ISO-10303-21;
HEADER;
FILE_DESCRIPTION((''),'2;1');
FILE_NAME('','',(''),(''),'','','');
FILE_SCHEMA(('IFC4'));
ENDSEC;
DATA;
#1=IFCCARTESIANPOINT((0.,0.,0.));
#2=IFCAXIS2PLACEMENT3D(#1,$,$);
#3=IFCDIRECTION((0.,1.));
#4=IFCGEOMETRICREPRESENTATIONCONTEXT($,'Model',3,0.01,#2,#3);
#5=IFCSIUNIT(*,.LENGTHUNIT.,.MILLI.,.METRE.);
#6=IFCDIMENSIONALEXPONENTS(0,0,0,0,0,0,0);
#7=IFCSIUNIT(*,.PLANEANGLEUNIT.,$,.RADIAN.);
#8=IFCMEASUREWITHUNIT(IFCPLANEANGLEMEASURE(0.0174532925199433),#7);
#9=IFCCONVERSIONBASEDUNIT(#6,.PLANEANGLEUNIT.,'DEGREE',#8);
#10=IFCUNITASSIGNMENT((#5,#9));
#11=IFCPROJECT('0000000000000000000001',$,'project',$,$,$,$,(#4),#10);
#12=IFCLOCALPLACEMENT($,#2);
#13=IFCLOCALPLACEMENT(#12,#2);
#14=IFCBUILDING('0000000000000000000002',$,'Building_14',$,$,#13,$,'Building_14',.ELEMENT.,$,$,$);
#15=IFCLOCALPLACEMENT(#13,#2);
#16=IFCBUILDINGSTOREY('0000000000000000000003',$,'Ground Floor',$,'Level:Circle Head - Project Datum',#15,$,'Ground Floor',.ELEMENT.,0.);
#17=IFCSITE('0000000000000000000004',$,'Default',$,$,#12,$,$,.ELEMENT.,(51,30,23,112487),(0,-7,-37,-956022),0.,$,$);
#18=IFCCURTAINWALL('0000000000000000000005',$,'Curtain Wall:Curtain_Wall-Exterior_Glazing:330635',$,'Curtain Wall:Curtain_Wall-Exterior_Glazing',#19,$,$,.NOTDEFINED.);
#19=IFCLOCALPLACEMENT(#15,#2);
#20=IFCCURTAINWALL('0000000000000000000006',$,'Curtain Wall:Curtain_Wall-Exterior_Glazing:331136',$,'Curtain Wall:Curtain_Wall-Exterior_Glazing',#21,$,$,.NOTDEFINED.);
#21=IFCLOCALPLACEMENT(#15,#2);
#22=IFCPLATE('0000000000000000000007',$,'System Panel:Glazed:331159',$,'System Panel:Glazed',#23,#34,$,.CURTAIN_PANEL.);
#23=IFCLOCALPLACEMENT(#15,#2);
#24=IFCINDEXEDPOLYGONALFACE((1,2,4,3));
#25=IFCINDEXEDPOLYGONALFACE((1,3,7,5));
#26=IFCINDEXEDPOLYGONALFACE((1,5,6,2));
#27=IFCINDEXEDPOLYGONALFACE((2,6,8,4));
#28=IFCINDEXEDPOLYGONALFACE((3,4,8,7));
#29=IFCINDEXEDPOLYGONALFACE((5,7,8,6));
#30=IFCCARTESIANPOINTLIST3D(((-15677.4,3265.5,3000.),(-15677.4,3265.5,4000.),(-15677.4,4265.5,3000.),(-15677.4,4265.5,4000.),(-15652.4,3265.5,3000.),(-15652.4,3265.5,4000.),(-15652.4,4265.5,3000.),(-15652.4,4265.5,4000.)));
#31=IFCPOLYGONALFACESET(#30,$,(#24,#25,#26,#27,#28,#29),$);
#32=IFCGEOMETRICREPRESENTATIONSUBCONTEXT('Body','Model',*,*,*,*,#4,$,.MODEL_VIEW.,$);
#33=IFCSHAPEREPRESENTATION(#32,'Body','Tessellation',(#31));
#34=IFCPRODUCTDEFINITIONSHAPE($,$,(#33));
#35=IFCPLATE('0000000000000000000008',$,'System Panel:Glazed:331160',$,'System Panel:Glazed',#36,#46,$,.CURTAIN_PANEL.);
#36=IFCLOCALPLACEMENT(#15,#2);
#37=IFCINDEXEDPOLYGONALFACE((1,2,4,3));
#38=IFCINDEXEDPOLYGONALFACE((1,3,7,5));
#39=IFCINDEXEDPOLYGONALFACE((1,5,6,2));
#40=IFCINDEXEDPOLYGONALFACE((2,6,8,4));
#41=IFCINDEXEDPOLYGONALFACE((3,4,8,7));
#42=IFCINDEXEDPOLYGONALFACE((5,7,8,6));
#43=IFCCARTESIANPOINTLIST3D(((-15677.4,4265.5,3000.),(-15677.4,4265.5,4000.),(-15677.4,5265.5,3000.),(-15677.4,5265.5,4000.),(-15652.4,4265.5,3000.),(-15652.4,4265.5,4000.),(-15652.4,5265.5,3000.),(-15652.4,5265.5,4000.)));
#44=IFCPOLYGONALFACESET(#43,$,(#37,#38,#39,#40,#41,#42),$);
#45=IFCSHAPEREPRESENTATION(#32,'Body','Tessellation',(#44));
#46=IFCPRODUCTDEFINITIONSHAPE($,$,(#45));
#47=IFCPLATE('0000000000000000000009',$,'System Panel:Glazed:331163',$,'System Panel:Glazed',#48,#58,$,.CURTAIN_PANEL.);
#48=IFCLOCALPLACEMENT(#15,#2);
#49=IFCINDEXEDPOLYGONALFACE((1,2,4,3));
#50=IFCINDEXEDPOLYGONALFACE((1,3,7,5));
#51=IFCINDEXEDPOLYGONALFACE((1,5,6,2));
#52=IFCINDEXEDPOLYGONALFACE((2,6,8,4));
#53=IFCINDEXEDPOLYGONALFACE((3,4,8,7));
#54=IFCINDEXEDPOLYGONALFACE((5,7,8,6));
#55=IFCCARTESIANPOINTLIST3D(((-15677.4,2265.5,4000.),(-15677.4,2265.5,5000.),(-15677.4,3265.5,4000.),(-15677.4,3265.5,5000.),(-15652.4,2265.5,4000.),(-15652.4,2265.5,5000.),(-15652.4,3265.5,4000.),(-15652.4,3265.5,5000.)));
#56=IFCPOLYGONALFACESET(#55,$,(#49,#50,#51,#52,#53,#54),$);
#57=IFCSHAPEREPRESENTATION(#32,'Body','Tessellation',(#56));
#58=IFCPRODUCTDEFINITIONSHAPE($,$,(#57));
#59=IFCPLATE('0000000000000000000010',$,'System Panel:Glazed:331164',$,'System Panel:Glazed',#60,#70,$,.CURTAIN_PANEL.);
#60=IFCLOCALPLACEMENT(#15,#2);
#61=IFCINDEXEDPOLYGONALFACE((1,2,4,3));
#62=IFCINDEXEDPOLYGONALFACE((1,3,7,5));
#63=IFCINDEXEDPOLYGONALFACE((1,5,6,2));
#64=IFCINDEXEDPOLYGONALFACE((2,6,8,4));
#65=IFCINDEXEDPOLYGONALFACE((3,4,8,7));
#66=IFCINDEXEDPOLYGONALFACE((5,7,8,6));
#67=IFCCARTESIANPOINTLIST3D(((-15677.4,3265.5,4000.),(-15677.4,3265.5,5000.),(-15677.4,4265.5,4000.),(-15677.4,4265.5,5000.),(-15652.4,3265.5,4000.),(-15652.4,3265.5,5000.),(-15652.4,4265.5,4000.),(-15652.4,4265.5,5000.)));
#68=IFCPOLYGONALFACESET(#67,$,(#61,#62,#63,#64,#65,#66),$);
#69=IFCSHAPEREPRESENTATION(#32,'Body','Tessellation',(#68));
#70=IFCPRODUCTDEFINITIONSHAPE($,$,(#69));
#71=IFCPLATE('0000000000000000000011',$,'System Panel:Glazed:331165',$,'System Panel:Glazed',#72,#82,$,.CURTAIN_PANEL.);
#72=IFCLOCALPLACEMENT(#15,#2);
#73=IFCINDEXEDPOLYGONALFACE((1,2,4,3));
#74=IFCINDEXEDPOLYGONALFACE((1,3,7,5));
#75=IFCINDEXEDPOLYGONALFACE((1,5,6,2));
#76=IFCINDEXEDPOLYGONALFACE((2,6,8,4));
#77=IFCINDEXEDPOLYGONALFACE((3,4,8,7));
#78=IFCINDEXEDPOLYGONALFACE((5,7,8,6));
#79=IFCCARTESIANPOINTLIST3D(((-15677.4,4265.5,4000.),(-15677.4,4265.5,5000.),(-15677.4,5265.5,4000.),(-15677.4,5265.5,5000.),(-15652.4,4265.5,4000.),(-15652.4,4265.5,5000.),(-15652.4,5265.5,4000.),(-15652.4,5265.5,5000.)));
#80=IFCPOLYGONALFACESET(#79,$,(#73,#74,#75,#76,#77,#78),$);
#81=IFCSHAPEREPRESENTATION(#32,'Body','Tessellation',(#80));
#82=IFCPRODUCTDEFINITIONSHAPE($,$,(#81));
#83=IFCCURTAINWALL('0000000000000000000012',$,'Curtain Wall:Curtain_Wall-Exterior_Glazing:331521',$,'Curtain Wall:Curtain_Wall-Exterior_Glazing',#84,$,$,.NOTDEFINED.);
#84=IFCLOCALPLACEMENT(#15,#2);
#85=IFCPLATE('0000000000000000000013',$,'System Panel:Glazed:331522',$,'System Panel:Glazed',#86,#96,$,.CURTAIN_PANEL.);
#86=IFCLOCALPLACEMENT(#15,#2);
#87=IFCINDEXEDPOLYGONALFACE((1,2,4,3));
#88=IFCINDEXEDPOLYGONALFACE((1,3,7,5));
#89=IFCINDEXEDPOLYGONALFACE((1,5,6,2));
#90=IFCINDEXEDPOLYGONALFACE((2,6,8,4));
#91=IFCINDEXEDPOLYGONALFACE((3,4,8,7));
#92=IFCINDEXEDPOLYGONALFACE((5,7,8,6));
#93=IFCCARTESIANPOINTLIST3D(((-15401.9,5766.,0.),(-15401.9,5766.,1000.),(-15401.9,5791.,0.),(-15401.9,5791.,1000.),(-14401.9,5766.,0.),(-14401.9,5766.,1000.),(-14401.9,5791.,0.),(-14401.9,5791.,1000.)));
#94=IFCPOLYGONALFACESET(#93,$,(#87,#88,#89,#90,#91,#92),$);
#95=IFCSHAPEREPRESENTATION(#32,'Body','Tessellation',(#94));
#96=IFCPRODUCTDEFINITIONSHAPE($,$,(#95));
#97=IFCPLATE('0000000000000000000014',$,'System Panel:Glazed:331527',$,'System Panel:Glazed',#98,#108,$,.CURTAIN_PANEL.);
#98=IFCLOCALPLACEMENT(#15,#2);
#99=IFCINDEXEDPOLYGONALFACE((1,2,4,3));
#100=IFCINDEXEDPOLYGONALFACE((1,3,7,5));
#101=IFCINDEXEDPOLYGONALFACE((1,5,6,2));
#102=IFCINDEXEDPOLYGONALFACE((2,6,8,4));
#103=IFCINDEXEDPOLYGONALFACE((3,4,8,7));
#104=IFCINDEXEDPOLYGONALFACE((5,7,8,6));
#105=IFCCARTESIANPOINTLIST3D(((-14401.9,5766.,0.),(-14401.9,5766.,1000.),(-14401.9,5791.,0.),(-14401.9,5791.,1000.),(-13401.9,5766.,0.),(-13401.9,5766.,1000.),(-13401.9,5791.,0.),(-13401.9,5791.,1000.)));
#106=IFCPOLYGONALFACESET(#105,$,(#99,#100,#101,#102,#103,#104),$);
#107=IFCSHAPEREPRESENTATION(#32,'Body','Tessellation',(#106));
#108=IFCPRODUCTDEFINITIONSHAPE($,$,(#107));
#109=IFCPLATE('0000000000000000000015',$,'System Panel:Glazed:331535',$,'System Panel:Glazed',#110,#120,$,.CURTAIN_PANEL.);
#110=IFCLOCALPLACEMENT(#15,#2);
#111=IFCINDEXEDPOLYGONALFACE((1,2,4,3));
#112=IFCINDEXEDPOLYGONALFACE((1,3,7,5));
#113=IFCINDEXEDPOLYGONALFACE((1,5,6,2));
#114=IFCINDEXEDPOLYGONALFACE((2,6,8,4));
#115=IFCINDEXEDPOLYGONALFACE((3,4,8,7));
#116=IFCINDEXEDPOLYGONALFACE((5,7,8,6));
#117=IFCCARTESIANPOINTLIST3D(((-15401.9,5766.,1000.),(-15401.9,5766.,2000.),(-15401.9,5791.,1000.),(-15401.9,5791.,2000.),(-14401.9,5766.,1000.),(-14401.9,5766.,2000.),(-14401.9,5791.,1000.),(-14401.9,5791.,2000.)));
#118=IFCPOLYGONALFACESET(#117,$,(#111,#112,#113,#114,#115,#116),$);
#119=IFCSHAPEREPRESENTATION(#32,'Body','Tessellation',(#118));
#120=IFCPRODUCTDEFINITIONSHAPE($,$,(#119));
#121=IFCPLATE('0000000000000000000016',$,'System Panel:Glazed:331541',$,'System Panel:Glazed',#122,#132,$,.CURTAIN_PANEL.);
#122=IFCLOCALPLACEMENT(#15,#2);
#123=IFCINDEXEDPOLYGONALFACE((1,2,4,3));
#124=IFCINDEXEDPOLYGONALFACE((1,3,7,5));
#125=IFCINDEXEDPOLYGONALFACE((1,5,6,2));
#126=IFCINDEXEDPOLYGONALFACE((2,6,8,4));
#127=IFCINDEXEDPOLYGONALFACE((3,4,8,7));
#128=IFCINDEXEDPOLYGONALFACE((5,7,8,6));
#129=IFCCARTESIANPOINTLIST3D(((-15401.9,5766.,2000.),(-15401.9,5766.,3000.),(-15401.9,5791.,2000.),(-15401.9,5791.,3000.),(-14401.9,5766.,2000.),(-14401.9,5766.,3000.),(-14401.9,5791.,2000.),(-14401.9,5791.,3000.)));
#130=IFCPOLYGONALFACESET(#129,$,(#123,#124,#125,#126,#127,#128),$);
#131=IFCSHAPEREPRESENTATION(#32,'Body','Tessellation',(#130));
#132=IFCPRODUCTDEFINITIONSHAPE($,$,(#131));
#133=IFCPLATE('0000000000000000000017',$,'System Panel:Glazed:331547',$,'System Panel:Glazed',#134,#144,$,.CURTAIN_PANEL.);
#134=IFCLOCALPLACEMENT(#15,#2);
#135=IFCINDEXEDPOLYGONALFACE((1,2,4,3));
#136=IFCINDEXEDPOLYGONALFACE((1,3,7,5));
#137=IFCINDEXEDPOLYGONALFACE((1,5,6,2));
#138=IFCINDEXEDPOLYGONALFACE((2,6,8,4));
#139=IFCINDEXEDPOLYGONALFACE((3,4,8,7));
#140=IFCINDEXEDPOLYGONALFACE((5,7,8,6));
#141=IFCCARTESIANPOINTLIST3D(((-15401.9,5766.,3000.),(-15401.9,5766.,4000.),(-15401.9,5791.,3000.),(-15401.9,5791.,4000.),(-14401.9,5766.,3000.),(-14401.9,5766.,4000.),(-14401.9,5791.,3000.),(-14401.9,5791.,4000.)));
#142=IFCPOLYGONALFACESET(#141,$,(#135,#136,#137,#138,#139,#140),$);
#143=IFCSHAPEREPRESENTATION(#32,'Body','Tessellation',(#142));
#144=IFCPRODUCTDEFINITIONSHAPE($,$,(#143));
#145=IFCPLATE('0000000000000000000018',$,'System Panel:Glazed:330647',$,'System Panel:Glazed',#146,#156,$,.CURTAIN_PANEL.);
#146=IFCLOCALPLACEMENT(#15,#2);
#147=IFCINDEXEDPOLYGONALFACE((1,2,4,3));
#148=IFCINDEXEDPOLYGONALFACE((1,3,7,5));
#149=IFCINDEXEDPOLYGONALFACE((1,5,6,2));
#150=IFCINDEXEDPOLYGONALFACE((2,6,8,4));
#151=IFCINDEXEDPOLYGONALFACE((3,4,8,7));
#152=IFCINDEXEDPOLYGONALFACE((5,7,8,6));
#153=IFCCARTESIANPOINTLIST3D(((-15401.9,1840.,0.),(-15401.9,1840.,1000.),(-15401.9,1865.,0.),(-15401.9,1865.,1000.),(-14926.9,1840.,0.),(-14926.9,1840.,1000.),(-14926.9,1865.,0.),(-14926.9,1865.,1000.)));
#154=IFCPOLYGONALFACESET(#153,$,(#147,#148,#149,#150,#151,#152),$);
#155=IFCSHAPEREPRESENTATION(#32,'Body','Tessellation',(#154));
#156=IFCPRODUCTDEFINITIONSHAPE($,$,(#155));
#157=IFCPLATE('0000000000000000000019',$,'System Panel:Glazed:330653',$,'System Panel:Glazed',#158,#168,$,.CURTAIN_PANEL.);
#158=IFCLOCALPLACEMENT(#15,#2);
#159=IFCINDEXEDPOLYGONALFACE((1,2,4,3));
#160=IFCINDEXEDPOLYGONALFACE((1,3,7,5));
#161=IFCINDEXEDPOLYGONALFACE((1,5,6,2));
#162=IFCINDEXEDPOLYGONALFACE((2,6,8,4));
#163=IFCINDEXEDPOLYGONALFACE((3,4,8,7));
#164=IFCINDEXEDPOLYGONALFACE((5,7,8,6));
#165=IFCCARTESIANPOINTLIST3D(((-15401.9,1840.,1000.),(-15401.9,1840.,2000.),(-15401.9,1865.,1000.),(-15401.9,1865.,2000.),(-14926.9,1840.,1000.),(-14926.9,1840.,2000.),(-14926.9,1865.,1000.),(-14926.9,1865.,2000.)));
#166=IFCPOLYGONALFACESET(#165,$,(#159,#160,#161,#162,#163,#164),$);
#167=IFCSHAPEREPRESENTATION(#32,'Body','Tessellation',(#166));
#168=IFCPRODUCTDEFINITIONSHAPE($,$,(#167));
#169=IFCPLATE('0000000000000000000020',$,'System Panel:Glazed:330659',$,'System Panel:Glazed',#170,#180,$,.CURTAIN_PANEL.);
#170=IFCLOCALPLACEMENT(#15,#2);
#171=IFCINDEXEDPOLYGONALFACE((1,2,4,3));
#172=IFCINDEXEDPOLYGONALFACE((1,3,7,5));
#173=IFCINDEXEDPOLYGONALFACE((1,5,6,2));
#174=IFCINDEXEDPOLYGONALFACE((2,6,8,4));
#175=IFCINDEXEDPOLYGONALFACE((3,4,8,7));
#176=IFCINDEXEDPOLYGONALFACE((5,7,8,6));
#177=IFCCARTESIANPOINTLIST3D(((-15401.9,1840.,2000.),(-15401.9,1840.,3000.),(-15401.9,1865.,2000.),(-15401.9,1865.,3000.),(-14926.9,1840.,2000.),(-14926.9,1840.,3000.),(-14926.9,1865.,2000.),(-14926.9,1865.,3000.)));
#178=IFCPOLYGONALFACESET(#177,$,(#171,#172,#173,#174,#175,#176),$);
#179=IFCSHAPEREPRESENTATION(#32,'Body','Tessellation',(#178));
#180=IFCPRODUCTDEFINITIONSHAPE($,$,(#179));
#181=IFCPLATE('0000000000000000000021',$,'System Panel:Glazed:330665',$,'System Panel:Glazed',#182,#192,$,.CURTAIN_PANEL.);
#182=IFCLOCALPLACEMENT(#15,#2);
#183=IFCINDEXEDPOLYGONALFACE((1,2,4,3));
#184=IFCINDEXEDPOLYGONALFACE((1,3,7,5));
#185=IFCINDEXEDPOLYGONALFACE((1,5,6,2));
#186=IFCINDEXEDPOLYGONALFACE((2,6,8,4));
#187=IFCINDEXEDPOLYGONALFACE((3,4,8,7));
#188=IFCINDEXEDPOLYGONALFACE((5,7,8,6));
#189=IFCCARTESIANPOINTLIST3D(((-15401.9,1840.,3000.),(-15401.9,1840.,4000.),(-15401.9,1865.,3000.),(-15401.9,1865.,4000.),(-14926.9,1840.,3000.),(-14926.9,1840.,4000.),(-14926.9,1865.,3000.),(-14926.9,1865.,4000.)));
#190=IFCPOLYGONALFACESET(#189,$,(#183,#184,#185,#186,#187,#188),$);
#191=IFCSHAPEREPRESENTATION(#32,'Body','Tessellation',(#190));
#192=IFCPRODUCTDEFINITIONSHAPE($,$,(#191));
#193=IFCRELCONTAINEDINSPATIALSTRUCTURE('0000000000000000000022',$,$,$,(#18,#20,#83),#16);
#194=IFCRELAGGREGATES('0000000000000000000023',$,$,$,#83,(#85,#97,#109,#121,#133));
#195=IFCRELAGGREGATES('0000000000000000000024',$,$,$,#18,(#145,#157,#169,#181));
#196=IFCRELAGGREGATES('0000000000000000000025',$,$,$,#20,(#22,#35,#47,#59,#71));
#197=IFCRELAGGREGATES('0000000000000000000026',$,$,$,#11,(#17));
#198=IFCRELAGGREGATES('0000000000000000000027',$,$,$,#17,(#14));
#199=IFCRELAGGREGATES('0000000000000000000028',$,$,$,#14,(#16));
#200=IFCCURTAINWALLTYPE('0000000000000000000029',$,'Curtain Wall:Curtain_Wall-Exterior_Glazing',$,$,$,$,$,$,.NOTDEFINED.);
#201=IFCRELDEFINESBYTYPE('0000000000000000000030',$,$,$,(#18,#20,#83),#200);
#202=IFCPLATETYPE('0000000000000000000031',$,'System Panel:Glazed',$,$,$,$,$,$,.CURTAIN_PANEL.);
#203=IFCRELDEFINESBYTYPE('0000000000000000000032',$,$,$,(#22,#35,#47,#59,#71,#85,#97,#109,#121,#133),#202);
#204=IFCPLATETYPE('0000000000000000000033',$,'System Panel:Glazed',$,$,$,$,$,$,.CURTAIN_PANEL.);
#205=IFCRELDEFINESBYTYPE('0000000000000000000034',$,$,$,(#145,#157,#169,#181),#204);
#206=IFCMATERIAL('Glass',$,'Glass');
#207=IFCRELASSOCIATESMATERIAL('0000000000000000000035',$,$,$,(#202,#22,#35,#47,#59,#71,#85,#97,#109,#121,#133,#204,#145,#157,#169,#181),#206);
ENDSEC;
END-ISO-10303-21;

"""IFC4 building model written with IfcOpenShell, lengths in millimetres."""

from ifc_helpers import new_model, entity, si_unit, converted_unit, direction, frame, origin, place, context, subcontext, project, spatial, indexed_curve, outline, extrude, source, transform, mapped, material, type_object, type_shapes, element, aggregate, save


model = new_model("IFC4")

# Units and contexts
model_context = context("Model", 3, precision=0.01, world=origin(), true_north=direction((0.0, 1.0)))
body_context = subcontext(model_context, "Body", "Model", "MODEL_VIEW")
ifc_project = project(units=[si_unit("LENGTHUNIT", "METRE", prefix="MILLI"), converted_unit("PLANEANGLEUNIT", "DEGREE", entity("IfcPlaneAngleMeasure", 0.0174532925199433), si_unit("PLANEANGLEUNIT", "RADIAN"), dimensions=[0, 0, 0, 0, 0, 0, 0])], contexts=[model_context])

# Site, building, storey
site_placement = place(None, origin())
site = spatial("IfcSite", under=ifc_project, at=site_placement, Name="Default", CompositionType="ELEMENT", RefLatitude=(51, 30, 23, 112487), RefLongitude=(0, -7, -37, -956022), RefElevation=0.0)
building_placement = place(site_placement, origin())
building = spatial("IfcBuilding", under=site, at=building_placement, Name="Building_14", LongName="Building_14", CompositionType="ELEMENT")
storey_placement = place(building_placement, origin())
storey = spatial("IfcBuildingStorey", under=building, at=storey_placement, Name="Ground Floor", ObjectType="Level:Circle Head - Project Datum", LongName="Ground Floor", CompositionType="ELEMENT", Elevation=0.0)

# Curtain walls, plates
curtain_wall_type = type_object("IfcCurtainWallType", Name="Curtain Wall:Curtain_Wall-Exterior_Glazing", PredefinedType="NOTDEFINED")
curtain_wall_1_placement = place(storey_placement, origin())
curtain_wall_1 = element("IfcCurtainWall", 1, at=curtain_wall_1_placement, inside=storey, type_object=curtain_wall_type, Name="Curtain Wall:Curtain_Wall-Exterior_Glazing:330635", ObjectType="Curtain Wall:Curtain_Wall-Exterior_Glazing", PredefinedType="NOTDEFINED")
ifc_material = material(Name="Glass", Category="Glass")
plate_type_1 = type_object("IfcPlateType", Name="System Panel:Glazed", PredefinedType="CURTAIN_PANEL", material=ifc_material)
shared_shape_1 = source(origin(), body_context, "Body", "SweptSolid", [
    extrude(outline(indexed_curve([(-12.5, -500.0), (12.5, -500.0), (12.5, 500.0), (-12.5, 500.0), (-12.5, -500.0)], self_intersect=False)), frame((0.0, -37.0, 0.0), z_axis=(0.0, 0.0, 1.0), x_axis=(0.0, 1.0, 0.0)), (0.0, 0.0, 1.0), 1000.0),
])
type_shapes(plate_type_1, [shared_shape_1])
curtain_wall_2_placement = place(storey_placement, origin())
curtain_wall_2 = element("IfcCurtainWall", 2, at=curtain_wall_2_placement, inside=storey, type_object=curtain_wall_type, Name="Curtain Wall:Curtain_Wall-Exterior_Glazing:331136", ObjectType="Curtain Wall:Curtain_Wall-Exterior_Glazing", PredefinedType="NOTDEFINED")
plate_1_placement = place(curtain_wall_2_placement, frame((-15701.9, 3765.5, 3000.0), z_axis=(0.0, 0.0, 1.0), x_axis=(0.0, 1.0, 0.0)))
plate_1 = element("IfcPlate", 3, at=plate_1_placement, type_object=plate_type_1, material=ifc_material, Name="System Panel:Glazed:331159", ObjectType="System Panel:Glazed", PredefinedType="CURTAIN_PANEL", context=body_context, shape_type="MappedRepresentation", body=[
    mapped(shared_shape_1, transform((0.0, 0.0, 0.0), scale=1.0)),
])
plate_2_placement = place(curtain_wall_2_placement, frame((-15701.9, 4765.5, 3000.0), z_axis=(0.0, 0.0, 1.0), x_axis=(0.0, 1.0, 0.0)))
plate_2 = element("IfcPlate", 4, at=plate_2_placement, type_object=plate_type_1, material=ifc_material, Name="System Panel:Glazed:331160", ObjectType="System Panel:Glazed", PredefinedType="CURTAIN_PANEL", context=body_context, shape_type="MappedRepresentation", body=[
    mapped(shared_shape_1, transform((0.0, 0.0, 0.0), scale=1.0)),
])
plate_3_placement = place(curtain_wall_2_placement, frame((-15701.9, 2765.5, 4000.0), z_axis=(0.0, 0.0, 1.0), x_axis=(0.0, 1.0, 0.0)))
plate_3 = element("IfcPlate", 5, at=plate_3_placement, type_object=plate_type_1, material=ifc_material, Name="System Panel:Glazed:331163", ObjectType="System Panel:Glazed", PredefinedType="CURTAIN_PANEL", context=body_context, shape_type="MappedRepresentation", body=[
    mapped(shared_shape_1, transform((0.0, 0.0, 0.0), scale=1.0)),
])
plate_4_placement = place(curtain_wall_2_placement, frame((-15701.9, 3765.5, 4000.0), z_axis=(0.0, 0.0, 1.0), x_axis=(0.0, 1.0, 0.0)))
plate_4 = element("IfcPlate", 6, at=plate_4_placement, type_object=plate_type_1, material=ifc_material, Name="System Panel:Glazed:331164", ObjectType="System Panel:Glazed", PredefinedType="CURTAIN_PANEL", context=body_context, shape_type="MappedRepresentation", body=[
    mapped(shared_shape_1, transform((0.0, 0.0, 0.0), scale=1.0)),
])
plate_5_placement = place(curtain_wall_2_placement, frame((-15701.9, 4765.5, 4000.0), z_axis=(0.0, 0.0, 1.0), x_axis=(0.0, 1.0, 0.0)))
plate_5 = element("IfcPlate", 7, at=plate_5_placement, type_object=plate_type_1, material=ifc_material, Name="System Panel:Glazed:331165", ObjectType="System Panel:Glazed", PredefinedType="CURTAIN_PANEL", context=body_context, shape_type="MappedRepresentation", body=[
    mapped(shared_shape_1, transform((0.0, 0.0, 0.0), scale=1.0)),
])
curtain_wall_3_placement = place(storey_placement, origin())
curtain_wall_3 = element("IfcCurtainWall", 8, at=curtain_wall_3_placement, inside=storey, type_object=curtain_wall_type, Name="Curtain Wall:Curtain_Wall-Exterior_Glazing:331521", ObjectType="Curtain Wall:Curtain_Wall-Exterior_Glazing", PredefinedType="NOTDEFINED")
plate_6_placement = place(curtain_wall_3_placement, frame((-14901.9, 5815.5, 0.0)))
plate_6 = element("IfcPlate", 9, at=plate_6_placement, type_object=plate_type_1, material=ifc_material, Name="System Panel:Glazed:331522", ObjectType="System Panel:Glazed", PredefinedType="CURTAIN_PANEL", context=body_context, shape_type="MappedRepresentation", body=[
    mapped(shared_shape_1, transform((0.0, 0.0, 0.0), scale=1.0)),
])
plate_7_placement = place(curtain_wall_3_placement, frame((-13901.9, 5815.5, 0.0)))
plate_7 = element("IfcPlate", 10, at=plate_7_placement, type_object=plate_type_1, material=ifc_material, Name="System Panel:Glazed:331527", ObjectType="System Panel:Glazed", PredefinedType="CURTAIN_PANEL", context=body_context, shape_type="MappedRepresentation", body=[
    mapped(shared_shape_1, transform((0.0, 0.0, 0.0), scale=1.0)),
])
plate_8_placement = place(curtain_wall_3_placement, frame((-14901.9, 5815.5, 1000.0)))
plate_8 = element("IfcPlate", 11, at=plate_8_placement, type_object=plate_type_1, material=ifc_material, Name="System Panel:Glazed:331535", ObjectType="System Panel:Glazed", PredefinedType="CURTAIN_PANEL", context=body_context, shape_type="MappedRepresentation", body=[
    mapped(shared_shape_1, transform((0.0, 0.0, 0.0), scale=1.0)),
])
plate_9_placement = place(curtain_wall_3_placement, frame((-14901.9, 5815.5, 2000.0)))
plate_9 = element("IfcPlate", 12, at=plate_9_placement, type_object=plate_type_1, material=ifc_material, Name="System Panel:Glazed:331541", ObjectType="System Panel:Glazed", PredefinedType="CURTAIN_PANEL", context=body_context, shape_type="MappedRepresentation", body=[
    mapped(shared_shape_1, transform((0.0, 0.0, 0.0), scale=1.0)),
])
plate_10_placement = place(curtain_wall_3_placement, frame((-14901.9, 5815.5, 3000.0)))
plate_10 = element("IfcPlate", 13, at=plate_10_placement, type_object=plate_type_1, material=ifc_material, Name="System Panel:Glazed:331547", ObjectType="System Panel:Glazed", PredefinedType="CURTAIN_PANEL", context=body_context, shape_type="MappedRepresentation", body=[
    mapped(shared_shape_1, transform((0.0, 0.0, 0.0), scale=1.0)),
])
aggregate(curtain_wall_3, [plate_6, plate_7, plate_8, plate_9, plate_10])

# Plates
plate_type_2 = type_object("IfcPlateType", Name="System Panel:Glazed", PredefinedType="CURTAIN_PANEL", material=ifc_material)
shared_shape_2 = source(origin(), body_context, "Body", "SweptSolid", [
    extrude(outline(indexed_curve([(-12.5, -237.5), (12.5, -237.5), (12.5, 237.5), (-12.5, 237.5), (-12.5, -237.5)], self_intersect=False)), frame((0.0, -37.0, 0.0), z_axis=(0.0, 0.0, 1.0), x_axis=(0.0, 1.0, 0.0)), (0.0, 0.0, 1.0), 1000.0),
])
type_shapes(plate_type_2, [shared_shape_2])
plate_11_placement = place(curtain_wall_1_placement, frame((-15164.4, 1815.5, 0.0), z_axis=(0.0, 0.0, 1.0), x_axis=(-1.0, 0.0, 0.0)))
plate_11 = element("IfcPlate", 14, at=plate_11_placement, type_object=plate_type_2, material=ifc_material, Name="System Panel:Glazed:330647", ObjectType="System Panel:Glazed", PredefinedType="CURTAIN_PANEL", context=body_context, shape_type="MappedRepresentation", body=[
    mapped(shared_shape_2, transform((0.0, 0.0, 0.0), scale=1.0)),
])
plate_12_placement = place(curtain_wall_1_placement, frame((-15164.4, 1815.5, 1000.0), z_axis=(0.0, 0.0, 1.0), x_axis=(-1.0, 0.0, 0.0)))
plate_12 = element("IfcPlate", 15, at=plate_12_placement, type_object=plate_type_2, material=ifc_material, Name="System Panel:Glazed:330653", ObjectType="System Panel:Glazed", PredefinedType="CURTAIN_PANEL", context=body_context, shape_type="MappedRepresentation", body=[
    mapped(shared_shape_2, transform((0.0, 0.0, 0.0), scale=1.0)),
])
plate_13_placement = place(curtain_wall_1_placement, frame((-15164.4, 1815.5, 2000.0), z_axis=(0.0, 0.0, 1.0), x_axis=(-1.0, 0.0, 0.0)))
plate_13 = element("IfcPlate", 16, at=plate_13_placement, type_object=plate_type_2, material=ifc_material, Name="System Panel:Glazed:330659", ObjectType="System Panel:Glazed", PredefinedType="CURTAIN_PANEL", context=body_context, shape_type="MappedRepresentation", body=[
    mapped(shared_shape_2, transform((0.0, 0.0, 0.0), scale=1.0)),
])
plate_14_placement = place(curtain_wall_1_placement, frame((-15164.4, 1815.5, 3000.0), z_axis=(0.0, 0.0, 1.0), x_axis=(-1.0, 0.0, 0.0)))
plate_14 = element("IfcPlate", 17, at=plate_14_placement, type_object=plate_type_2, material=ifc_material, Name="System Panel:Glazed:330665", ObjectType="System Panel:Glazed", PredefinedType="CURTAIN_PANEL", context=body_context, shape_type="MappedRepresentation", body=[
    mapped(shared_shape_2, transform((0.0, 0.0, 0.0), scale=1.0)),
])
aggregate(curtain_wall_1, [plate_11, plate_12, plate_13, plate_14])
aggregate(curtain_wall_2, [plate_1, plate_2, plate_3, plate_4, plate_5])

save(model, "model.ifc")
